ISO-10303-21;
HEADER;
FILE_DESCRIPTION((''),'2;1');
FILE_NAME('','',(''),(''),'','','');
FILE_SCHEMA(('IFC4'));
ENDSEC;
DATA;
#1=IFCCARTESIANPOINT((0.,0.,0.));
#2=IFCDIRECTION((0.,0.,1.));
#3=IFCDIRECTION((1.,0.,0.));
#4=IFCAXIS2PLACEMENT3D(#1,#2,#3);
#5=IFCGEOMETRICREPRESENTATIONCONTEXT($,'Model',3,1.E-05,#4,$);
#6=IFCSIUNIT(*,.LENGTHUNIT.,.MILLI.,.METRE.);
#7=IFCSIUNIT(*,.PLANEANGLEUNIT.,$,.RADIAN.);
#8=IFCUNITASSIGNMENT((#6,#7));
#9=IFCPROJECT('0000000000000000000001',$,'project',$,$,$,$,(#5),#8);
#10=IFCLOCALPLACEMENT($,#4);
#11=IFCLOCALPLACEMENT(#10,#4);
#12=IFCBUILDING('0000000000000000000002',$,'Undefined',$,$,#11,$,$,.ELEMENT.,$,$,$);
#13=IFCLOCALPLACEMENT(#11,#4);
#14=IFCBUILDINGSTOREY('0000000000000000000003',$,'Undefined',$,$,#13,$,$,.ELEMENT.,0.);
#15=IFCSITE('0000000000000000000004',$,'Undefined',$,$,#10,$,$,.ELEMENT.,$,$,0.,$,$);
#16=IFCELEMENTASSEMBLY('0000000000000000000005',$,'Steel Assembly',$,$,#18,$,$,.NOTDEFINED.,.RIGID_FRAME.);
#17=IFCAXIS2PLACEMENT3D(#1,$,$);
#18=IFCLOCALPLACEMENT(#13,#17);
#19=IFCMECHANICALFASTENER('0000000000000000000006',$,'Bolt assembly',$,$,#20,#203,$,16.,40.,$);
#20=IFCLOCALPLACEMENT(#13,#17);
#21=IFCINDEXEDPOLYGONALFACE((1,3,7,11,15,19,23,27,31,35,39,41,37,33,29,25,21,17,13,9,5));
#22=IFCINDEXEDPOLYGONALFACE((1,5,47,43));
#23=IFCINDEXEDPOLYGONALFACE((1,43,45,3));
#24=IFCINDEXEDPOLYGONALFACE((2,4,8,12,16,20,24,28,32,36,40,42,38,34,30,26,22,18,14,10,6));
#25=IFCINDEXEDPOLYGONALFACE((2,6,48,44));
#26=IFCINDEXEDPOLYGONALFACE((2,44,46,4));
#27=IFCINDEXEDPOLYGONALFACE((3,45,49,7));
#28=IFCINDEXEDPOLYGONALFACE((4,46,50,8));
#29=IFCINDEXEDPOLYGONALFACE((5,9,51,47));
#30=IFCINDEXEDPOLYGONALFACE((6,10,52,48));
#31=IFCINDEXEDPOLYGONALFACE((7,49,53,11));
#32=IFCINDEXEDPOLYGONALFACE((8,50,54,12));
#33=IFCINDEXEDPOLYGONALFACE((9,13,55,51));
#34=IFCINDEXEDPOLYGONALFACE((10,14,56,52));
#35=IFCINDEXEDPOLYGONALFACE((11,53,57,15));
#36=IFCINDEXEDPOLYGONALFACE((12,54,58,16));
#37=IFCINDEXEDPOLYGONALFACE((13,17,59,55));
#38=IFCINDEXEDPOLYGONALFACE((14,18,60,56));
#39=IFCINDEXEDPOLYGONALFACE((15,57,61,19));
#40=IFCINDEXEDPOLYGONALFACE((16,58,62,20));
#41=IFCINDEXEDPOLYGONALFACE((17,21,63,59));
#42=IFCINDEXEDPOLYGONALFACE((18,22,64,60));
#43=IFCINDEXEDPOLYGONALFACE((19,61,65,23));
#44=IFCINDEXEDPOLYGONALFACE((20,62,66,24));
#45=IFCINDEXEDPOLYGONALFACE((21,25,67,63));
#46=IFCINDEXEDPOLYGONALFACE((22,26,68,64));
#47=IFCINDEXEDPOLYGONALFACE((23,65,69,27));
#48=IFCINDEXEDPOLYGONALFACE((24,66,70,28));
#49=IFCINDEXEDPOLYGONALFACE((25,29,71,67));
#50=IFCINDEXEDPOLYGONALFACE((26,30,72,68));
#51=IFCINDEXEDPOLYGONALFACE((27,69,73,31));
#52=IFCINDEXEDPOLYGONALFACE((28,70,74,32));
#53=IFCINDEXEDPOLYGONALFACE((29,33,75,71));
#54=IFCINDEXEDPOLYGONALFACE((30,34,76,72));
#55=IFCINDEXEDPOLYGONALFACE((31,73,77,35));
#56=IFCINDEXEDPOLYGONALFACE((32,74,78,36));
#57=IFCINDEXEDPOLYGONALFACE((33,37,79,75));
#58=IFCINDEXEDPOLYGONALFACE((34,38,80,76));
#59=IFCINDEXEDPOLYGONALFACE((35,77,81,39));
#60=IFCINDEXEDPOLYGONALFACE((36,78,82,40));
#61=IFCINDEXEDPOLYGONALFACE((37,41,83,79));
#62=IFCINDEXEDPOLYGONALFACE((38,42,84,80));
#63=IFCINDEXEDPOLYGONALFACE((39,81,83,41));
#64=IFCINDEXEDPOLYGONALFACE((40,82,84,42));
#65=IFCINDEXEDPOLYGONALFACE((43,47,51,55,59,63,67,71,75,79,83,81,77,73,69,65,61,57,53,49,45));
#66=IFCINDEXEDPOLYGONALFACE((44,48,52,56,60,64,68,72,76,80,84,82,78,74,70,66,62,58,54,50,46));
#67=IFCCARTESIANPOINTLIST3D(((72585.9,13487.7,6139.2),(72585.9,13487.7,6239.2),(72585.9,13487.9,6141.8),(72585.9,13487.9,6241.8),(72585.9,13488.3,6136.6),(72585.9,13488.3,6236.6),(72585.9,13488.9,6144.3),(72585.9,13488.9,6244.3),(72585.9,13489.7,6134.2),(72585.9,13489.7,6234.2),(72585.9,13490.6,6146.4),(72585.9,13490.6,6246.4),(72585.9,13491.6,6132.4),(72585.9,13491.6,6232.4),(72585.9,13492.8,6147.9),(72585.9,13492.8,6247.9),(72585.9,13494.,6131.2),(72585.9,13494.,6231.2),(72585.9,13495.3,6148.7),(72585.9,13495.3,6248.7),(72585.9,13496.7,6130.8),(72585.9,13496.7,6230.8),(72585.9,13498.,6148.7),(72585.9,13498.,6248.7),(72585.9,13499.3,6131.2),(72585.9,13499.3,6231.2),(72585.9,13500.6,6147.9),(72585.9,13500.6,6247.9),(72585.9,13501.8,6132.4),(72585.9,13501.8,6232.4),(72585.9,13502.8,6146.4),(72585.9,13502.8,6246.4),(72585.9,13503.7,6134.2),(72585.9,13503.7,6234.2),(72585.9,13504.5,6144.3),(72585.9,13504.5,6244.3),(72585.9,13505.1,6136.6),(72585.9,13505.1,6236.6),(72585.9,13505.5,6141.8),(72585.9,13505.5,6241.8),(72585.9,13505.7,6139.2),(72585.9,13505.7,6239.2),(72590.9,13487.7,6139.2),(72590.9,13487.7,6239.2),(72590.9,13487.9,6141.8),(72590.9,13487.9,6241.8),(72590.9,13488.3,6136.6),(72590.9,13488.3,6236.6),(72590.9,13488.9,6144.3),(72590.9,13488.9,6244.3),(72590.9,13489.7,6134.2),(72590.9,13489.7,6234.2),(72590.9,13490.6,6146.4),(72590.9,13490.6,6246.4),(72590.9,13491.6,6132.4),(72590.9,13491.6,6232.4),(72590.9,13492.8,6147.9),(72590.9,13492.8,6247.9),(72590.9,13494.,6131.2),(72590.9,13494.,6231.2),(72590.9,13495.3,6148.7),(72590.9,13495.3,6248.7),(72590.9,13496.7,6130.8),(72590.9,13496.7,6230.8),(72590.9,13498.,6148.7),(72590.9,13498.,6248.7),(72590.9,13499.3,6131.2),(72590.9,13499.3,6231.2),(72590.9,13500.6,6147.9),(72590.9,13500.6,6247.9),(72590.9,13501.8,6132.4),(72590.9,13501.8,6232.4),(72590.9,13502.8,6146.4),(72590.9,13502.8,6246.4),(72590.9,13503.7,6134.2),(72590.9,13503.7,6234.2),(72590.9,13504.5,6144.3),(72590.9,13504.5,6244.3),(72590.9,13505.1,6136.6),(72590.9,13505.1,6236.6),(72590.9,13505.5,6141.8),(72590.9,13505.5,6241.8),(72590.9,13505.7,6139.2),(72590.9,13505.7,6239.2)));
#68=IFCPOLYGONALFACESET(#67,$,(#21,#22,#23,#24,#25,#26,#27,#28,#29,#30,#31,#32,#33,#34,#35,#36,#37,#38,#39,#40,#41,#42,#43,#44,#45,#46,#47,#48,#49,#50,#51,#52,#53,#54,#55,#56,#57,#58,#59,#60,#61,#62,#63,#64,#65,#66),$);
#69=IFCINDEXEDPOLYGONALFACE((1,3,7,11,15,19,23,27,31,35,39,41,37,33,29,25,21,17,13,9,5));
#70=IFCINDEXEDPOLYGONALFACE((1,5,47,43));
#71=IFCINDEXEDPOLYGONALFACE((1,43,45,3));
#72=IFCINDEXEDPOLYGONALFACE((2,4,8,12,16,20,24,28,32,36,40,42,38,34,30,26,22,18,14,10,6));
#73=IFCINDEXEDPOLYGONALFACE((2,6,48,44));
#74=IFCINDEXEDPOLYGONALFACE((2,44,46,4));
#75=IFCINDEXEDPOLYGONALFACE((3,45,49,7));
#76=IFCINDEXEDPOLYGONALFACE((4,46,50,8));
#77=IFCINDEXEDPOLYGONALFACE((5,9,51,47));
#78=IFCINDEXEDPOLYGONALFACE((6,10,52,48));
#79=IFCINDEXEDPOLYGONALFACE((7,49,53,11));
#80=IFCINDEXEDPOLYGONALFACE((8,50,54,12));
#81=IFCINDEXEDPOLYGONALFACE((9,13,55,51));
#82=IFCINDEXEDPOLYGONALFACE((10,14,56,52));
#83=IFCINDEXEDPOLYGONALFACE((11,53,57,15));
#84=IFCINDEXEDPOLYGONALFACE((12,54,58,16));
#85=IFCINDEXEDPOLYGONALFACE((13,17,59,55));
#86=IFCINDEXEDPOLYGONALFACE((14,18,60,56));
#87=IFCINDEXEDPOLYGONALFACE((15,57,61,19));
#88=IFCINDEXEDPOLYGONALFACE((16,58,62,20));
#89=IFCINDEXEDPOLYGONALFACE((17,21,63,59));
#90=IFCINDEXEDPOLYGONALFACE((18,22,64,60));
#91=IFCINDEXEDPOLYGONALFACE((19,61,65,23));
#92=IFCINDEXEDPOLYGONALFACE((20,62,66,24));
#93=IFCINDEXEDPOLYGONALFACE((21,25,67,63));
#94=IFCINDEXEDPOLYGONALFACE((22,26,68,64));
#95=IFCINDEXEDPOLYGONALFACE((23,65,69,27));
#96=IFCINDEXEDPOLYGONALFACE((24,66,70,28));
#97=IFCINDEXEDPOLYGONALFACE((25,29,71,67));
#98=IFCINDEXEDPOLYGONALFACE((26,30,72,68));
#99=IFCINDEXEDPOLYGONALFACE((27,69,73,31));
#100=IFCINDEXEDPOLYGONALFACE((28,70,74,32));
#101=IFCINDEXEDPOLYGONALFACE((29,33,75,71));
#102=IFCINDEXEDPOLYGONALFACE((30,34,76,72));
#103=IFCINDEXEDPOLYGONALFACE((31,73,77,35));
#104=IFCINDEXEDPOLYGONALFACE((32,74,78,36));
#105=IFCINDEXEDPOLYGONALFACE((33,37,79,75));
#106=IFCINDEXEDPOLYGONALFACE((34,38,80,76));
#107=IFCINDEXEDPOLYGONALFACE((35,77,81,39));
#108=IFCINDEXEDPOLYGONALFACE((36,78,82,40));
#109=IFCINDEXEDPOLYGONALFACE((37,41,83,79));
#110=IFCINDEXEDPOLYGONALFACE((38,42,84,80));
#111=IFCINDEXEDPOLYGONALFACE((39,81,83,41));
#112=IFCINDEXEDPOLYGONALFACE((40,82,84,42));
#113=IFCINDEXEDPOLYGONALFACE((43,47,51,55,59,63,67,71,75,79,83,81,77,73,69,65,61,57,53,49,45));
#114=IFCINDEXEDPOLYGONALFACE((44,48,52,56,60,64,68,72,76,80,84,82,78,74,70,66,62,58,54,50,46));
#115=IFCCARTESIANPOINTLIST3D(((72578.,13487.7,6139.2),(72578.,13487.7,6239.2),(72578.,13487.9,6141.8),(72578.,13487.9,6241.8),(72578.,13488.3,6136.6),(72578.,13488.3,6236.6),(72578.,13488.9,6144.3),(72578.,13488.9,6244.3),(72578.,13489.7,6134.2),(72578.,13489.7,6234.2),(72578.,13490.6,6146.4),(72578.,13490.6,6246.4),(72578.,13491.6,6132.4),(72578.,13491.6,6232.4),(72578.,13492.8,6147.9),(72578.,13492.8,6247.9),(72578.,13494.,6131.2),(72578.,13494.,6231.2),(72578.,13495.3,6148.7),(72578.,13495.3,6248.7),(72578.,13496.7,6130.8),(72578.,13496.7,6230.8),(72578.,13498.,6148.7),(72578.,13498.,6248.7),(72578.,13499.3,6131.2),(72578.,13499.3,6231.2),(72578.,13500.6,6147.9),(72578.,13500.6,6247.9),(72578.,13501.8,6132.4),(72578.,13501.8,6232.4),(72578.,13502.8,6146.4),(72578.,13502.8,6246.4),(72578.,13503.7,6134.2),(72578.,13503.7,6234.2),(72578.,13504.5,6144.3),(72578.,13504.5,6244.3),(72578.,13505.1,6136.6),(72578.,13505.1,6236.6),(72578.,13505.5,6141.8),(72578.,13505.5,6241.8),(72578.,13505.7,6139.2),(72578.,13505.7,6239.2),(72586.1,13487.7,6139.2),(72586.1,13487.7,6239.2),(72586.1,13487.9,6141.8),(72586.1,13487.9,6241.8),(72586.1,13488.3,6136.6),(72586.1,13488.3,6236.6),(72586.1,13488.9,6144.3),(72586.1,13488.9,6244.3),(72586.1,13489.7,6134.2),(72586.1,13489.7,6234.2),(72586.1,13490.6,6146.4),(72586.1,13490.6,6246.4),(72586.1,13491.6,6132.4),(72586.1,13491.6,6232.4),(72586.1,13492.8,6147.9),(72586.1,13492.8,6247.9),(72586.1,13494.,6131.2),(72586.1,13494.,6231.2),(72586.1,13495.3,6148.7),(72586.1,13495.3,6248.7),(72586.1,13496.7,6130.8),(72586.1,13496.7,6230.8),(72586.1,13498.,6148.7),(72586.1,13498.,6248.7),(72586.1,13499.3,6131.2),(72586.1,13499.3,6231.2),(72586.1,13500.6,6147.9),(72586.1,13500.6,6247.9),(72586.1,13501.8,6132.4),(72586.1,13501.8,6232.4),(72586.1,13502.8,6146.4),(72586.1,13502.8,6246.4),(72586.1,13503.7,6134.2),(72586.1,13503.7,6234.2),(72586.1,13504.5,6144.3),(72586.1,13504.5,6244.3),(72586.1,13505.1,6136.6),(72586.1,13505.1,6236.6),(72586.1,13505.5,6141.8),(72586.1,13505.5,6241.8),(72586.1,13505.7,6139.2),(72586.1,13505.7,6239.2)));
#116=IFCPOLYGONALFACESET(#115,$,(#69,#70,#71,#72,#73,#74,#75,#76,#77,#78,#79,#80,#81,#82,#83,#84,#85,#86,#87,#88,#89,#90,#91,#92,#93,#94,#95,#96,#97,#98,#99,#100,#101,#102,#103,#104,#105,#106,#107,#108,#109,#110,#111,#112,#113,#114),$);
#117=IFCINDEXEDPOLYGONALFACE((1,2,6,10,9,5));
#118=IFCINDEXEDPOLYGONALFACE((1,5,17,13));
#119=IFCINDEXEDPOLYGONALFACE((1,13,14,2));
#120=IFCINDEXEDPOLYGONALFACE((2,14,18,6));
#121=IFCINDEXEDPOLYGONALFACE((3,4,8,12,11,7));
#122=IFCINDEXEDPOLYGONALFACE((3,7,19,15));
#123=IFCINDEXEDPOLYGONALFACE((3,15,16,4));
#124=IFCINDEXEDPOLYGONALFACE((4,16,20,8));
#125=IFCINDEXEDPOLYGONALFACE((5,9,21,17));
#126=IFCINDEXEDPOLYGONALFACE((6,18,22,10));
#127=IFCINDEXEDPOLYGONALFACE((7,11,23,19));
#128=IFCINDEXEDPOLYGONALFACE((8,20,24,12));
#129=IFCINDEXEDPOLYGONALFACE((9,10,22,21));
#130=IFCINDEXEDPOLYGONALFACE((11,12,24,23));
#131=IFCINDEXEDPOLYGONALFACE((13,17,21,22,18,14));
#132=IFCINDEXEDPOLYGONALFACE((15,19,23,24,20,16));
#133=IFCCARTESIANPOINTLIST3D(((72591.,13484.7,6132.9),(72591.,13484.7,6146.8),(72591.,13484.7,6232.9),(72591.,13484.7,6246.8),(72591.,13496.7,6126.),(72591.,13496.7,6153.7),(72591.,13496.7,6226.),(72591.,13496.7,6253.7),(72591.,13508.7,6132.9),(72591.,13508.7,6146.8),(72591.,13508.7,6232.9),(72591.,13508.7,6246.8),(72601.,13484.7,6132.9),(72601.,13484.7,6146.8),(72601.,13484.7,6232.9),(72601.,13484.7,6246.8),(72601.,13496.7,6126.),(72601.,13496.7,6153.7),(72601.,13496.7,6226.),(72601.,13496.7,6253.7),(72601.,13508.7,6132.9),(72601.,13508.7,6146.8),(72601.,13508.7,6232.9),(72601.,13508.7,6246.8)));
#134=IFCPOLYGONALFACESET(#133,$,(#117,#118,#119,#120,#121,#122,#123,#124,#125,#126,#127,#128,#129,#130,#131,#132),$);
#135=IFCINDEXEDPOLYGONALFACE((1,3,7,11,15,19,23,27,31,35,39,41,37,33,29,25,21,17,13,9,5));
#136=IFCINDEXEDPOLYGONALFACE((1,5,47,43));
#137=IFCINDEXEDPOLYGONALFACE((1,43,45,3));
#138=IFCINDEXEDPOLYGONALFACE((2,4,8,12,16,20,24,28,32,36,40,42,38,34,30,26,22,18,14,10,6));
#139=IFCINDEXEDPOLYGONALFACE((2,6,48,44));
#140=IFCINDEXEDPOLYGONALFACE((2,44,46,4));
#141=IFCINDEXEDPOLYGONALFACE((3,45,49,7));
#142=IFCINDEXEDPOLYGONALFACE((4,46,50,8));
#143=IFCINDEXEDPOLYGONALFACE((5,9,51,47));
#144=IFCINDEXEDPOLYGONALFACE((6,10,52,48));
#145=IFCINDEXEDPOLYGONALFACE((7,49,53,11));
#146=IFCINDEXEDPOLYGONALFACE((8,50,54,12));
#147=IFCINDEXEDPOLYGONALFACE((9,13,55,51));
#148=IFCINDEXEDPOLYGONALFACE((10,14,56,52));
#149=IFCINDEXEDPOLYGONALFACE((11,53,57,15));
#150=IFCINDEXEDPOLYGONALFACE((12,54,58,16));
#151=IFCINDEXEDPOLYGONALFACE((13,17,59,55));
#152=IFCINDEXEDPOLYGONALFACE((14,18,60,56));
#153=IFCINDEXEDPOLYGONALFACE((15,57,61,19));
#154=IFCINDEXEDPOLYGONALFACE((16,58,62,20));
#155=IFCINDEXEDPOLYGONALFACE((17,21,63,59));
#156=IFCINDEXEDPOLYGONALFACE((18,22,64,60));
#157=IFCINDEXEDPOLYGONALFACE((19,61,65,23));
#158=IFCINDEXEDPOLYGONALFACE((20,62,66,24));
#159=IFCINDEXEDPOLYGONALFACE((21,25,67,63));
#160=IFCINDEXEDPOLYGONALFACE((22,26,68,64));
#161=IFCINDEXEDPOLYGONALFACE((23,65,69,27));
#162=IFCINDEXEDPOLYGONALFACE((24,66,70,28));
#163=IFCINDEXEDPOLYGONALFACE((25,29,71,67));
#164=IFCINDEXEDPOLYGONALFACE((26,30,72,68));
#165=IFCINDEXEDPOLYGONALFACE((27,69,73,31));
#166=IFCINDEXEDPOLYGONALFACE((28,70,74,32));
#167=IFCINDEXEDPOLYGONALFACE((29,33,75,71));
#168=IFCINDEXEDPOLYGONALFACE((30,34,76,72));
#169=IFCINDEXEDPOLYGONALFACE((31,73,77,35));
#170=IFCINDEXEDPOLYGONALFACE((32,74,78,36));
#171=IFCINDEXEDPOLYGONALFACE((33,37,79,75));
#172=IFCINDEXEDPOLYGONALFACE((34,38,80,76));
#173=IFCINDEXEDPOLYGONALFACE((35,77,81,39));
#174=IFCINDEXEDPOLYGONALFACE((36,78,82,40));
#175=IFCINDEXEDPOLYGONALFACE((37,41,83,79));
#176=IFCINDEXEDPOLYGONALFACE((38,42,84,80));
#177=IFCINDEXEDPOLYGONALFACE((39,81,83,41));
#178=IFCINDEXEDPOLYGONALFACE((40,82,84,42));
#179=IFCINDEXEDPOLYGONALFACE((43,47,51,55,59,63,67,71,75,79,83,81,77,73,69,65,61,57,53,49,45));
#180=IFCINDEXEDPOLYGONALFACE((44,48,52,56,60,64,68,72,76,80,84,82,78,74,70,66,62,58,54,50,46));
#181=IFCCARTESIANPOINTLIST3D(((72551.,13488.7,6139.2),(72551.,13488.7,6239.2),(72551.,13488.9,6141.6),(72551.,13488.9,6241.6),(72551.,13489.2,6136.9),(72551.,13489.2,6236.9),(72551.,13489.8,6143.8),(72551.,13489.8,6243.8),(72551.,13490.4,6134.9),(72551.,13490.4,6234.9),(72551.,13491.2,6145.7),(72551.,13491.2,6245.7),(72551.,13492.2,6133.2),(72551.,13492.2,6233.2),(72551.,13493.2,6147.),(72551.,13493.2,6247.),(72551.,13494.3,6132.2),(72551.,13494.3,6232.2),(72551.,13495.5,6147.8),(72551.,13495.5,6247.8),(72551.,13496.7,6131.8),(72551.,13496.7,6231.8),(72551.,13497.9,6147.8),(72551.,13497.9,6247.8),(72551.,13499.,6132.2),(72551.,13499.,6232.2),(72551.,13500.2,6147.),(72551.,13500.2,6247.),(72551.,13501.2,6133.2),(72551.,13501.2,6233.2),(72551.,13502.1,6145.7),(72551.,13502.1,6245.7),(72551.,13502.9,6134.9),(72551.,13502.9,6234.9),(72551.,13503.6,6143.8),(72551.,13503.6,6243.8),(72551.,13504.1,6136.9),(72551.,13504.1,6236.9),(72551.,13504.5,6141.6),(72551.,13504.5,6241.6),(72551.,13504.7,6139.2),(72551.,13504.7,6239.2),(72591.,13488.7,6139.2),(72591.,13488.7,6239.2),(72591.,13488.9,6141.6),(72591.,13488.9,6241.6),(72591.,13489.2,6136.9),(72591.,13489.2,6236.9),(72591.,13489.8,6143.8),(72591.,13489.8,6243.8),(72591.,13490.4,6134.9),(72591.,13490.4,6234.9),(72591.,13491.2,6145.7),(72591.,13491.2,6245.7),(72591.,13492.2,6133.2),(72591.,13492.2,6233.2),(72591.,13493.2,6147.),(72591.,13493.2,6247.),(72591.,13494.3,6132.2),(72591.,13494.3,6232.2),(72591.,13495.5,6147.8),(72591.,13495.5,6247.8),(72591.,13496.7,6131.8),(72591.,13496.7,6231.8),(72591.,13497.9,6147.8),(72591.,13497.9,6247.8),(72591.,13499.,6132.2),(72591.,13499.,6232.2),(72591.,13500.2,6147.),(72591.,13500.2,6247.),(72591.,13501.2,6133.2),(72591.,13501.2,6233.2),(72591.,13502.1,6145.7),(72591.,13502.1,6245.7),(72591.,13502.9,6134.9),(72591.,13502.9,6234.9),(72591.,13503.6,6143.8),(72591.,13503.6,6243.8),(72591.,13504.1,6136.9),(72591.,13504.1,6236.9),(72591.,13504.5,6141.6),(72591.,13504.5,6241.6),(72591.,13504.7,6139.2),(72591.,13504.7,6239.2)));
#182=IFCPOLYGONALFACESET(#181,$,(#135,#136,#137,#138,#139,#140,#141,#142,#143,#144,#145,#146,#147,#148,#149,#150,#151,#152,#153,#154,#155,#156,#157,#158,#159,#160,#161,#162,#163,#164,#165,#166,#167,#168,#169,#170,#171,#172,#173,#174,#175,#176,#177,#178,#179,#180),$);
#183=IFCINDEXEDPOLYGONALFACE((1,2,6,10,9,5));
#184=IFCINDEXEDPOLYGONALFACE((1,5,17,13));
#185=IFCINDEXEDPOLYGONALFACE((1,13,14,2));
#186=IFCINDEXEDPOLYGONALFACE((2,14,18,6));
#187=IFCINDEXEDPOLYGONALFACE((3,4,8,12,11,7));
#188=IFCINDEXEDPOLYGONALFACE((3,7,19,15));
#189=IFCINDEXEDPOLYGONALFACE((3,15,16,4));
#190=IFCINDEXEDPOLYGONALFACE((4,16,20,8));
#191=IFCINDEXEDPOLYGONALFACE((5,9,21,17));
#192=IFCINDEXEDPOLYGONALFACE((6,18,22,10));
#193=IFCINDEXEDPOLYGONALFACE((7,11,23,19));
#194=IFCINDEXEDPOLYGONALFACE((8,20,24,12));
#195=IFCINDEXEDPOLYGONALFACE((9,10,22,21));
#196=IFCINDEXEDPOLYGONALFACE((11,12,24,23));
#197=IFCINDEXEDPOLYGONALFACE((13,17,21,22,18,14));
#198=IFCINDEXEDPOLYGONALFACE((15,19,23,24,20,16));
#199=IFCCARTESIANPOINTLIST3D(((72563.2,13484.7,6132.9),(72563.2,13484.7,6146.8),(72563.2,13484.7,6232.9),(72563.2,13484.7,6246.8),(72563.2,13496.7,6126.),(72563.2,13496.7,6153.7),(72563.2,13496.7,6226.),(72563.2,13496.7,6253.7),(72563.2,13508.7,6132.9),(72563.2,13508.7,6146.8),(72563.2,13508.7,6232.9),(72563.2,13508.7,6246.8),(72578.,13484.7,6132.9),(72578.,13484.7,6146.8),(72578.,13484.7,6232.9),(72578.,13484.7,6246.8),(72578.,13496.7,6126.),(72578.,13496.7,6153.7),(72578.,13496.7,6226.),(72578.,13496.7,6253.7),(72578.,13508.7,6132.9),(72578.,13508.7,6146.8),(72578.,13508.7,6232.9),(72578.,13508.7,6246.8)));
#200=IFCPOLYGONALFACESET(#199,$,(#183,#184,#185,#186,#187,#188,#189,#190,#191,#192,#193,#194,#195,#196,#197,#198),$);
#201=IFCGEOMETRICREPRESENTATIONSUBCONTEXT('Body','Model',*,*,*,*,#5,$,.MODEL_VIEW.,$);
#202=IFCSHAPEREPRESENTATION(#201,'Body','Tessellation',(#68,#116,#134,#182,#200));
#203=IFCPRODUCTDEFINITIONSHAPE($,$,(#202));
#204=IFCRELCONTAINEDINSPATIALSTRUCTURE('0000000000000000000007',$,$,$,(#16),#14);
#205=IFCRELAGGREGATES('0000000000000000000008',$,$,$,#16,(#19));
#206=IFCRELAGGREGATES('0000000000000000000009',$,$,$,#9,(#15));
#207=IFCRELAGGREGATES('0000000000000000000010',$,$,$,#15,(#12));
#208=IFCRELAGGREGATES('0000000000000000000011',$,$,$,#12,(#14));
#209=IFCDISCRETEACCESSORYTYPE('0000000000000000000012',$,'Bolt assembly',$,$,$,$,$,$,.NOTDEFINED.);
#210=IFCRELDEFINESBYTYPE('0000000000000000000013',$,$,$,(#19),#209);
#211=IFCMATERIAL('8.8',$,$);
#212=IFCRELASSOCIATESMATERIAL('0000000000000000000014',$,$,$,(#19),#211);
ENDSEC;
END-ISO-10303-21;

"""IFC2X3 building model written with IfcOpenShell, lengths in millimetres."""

from ifc_helpers import new_model, si_unit, frame, origin_with_axes, origin_2d_with_axis, place, context, subcontext, project, spatial, polyline, circle, outline, extrude, source, transform, mapped, material, type_object, element, aggregate, save


model = new_model("IFC2X3")

# Units and contexts
model_context = context("Model", 3, precision=1e-05, world=origin_with_axes())
body_context = subcontext(model_context, "Body", "Model", "MODEL_VIEW")
ifc_project = project(units=[si_unit("LENGTHUNIT", "METRE", prefix="MILLI"), si_unit("PLANEANGLEUNIT", "RADIAN")], contexts=[model_context])

# Site, building, storey
site_placement = place(None, origin_with_axes())
site = spatial("IfcSite", under=ifc_project, at=site_placement, Name="Undefined", CompositionType="ELEMENT", RefElevation=0.0)
building_placement = place(site_placement, origin_with_axes())
building = spatial("IfcBuilding", under=site, at=building_placement, Name="Undefined", CompositionType="ELEMENT")
storey_placement = place(building_placement, origin_with_axes())
storey = spatial("IfcBuildingStorey", under=building, at=storey_placement, Name="Undefined", CompositionType="ELEMENT", Elevation=0.0)

# Element assembly
assembly_1_placement = place(storey_placement, origin_with_axes())
assembly_1 = element("IfcElementAssembly", 1, at=assembly_1_placement, inside=storey, Name="Steel Assembly", AssemblyPlace="NOTDEFINED", PredefinedType="RIGID_FRAME")

# Shared definitions
discrete_accessory_type_1 = type_object("IfcDiscreteAccessoryType", Name="Bolt assembly")
ifc_material_1 = material(Name="8.8")

# Mechanical fastener
shared_shape_1 = source(origin_with_axes(), body_context, "Body", "SweptSolid", [
    extrude(circle(Radius=9.0, at=origin_2d_with_axis()), frame((0.0, -4.9, 0.0), z_axis=(0.0, 1.0, 0.0), x_axis=(1.0, 0.0, 0.0)), (0.0, 0.0, 1.0), 5.0),
    extrude(circle(Radius=9.0, at=origin_2d_with_axis()), frame((0.0, -0.1, 0.0), z_axis=(0.0, 1.0, 0.0), x_axis=(1.0, 0.0, 0.0)), (0.0, 0.0, 1.0), 8.1),
    extrude(outline(polyline([(13.9, 0.0), (6.9, 12.0), (-6.9, 12.0), (-13.9, 0.0), (-6.9, -12.0), (6.9, -12.0), (13.9, 0.0)])), frame((0.0, -15.0, 0.0), z_axis=(0.0, 1.0, 0.0), x_axis=(1.0, 0.0, 0.0)), (0.0, 0.0, 1.0), 10.0),
    extrude(circle(Radius=8.0, at=origin_2d_with_axis()), frame((0.0, -5.0, 0.0), z_axis=(0.0, 1.0, 0.0), x_axis=(1.0, 0.0, 0.0)), (0.0, 0.0, 1.0), 40.0),
    extrude(outline(polyline([(13.9, 0.0), (6.9, 12.0), (-6.9, 12.0), (-13.9, 0.0), (-6.9, -12.0), (6.9, -12.0), (13.9, 0.0)])), frame((0.0, 8.0, 0.0), z_axis=(0.0, 1.0, 0.0), x_axis=(1.0, 0.0, 0.0)), (0.0, 0.0, 1.0), 14.8),
])
mechanical_fastener_1_placement = place(assembly_1_placement, frame((72586.0, 13496.7, 6239.8), z_axis=(0.0, 1.0, 0.0), x_axis=(-0.000056, 0.0, -1.0)))
mechanical_fastener_1 = element("IfcMechanicalFastener", 2, at=mechanical_fastener_1_placement, type_object=discrete_accessory_type_1, material=ifc_material_1, Name="Bolt assembly", NominalDiameter=16.0, NominalLength=40.0, context=body_context, shape_type="MappedRepresentation", body=[
    mapped(shared_shape_1, transform((0.0, 0.0, 0.0))),
    mapped(shared_shape_1, transform((100.0, 0.0, 0.0))),
])
aggregate(assembly_1, [mechanical_fastener_1])

save(model, "model.ifc")
